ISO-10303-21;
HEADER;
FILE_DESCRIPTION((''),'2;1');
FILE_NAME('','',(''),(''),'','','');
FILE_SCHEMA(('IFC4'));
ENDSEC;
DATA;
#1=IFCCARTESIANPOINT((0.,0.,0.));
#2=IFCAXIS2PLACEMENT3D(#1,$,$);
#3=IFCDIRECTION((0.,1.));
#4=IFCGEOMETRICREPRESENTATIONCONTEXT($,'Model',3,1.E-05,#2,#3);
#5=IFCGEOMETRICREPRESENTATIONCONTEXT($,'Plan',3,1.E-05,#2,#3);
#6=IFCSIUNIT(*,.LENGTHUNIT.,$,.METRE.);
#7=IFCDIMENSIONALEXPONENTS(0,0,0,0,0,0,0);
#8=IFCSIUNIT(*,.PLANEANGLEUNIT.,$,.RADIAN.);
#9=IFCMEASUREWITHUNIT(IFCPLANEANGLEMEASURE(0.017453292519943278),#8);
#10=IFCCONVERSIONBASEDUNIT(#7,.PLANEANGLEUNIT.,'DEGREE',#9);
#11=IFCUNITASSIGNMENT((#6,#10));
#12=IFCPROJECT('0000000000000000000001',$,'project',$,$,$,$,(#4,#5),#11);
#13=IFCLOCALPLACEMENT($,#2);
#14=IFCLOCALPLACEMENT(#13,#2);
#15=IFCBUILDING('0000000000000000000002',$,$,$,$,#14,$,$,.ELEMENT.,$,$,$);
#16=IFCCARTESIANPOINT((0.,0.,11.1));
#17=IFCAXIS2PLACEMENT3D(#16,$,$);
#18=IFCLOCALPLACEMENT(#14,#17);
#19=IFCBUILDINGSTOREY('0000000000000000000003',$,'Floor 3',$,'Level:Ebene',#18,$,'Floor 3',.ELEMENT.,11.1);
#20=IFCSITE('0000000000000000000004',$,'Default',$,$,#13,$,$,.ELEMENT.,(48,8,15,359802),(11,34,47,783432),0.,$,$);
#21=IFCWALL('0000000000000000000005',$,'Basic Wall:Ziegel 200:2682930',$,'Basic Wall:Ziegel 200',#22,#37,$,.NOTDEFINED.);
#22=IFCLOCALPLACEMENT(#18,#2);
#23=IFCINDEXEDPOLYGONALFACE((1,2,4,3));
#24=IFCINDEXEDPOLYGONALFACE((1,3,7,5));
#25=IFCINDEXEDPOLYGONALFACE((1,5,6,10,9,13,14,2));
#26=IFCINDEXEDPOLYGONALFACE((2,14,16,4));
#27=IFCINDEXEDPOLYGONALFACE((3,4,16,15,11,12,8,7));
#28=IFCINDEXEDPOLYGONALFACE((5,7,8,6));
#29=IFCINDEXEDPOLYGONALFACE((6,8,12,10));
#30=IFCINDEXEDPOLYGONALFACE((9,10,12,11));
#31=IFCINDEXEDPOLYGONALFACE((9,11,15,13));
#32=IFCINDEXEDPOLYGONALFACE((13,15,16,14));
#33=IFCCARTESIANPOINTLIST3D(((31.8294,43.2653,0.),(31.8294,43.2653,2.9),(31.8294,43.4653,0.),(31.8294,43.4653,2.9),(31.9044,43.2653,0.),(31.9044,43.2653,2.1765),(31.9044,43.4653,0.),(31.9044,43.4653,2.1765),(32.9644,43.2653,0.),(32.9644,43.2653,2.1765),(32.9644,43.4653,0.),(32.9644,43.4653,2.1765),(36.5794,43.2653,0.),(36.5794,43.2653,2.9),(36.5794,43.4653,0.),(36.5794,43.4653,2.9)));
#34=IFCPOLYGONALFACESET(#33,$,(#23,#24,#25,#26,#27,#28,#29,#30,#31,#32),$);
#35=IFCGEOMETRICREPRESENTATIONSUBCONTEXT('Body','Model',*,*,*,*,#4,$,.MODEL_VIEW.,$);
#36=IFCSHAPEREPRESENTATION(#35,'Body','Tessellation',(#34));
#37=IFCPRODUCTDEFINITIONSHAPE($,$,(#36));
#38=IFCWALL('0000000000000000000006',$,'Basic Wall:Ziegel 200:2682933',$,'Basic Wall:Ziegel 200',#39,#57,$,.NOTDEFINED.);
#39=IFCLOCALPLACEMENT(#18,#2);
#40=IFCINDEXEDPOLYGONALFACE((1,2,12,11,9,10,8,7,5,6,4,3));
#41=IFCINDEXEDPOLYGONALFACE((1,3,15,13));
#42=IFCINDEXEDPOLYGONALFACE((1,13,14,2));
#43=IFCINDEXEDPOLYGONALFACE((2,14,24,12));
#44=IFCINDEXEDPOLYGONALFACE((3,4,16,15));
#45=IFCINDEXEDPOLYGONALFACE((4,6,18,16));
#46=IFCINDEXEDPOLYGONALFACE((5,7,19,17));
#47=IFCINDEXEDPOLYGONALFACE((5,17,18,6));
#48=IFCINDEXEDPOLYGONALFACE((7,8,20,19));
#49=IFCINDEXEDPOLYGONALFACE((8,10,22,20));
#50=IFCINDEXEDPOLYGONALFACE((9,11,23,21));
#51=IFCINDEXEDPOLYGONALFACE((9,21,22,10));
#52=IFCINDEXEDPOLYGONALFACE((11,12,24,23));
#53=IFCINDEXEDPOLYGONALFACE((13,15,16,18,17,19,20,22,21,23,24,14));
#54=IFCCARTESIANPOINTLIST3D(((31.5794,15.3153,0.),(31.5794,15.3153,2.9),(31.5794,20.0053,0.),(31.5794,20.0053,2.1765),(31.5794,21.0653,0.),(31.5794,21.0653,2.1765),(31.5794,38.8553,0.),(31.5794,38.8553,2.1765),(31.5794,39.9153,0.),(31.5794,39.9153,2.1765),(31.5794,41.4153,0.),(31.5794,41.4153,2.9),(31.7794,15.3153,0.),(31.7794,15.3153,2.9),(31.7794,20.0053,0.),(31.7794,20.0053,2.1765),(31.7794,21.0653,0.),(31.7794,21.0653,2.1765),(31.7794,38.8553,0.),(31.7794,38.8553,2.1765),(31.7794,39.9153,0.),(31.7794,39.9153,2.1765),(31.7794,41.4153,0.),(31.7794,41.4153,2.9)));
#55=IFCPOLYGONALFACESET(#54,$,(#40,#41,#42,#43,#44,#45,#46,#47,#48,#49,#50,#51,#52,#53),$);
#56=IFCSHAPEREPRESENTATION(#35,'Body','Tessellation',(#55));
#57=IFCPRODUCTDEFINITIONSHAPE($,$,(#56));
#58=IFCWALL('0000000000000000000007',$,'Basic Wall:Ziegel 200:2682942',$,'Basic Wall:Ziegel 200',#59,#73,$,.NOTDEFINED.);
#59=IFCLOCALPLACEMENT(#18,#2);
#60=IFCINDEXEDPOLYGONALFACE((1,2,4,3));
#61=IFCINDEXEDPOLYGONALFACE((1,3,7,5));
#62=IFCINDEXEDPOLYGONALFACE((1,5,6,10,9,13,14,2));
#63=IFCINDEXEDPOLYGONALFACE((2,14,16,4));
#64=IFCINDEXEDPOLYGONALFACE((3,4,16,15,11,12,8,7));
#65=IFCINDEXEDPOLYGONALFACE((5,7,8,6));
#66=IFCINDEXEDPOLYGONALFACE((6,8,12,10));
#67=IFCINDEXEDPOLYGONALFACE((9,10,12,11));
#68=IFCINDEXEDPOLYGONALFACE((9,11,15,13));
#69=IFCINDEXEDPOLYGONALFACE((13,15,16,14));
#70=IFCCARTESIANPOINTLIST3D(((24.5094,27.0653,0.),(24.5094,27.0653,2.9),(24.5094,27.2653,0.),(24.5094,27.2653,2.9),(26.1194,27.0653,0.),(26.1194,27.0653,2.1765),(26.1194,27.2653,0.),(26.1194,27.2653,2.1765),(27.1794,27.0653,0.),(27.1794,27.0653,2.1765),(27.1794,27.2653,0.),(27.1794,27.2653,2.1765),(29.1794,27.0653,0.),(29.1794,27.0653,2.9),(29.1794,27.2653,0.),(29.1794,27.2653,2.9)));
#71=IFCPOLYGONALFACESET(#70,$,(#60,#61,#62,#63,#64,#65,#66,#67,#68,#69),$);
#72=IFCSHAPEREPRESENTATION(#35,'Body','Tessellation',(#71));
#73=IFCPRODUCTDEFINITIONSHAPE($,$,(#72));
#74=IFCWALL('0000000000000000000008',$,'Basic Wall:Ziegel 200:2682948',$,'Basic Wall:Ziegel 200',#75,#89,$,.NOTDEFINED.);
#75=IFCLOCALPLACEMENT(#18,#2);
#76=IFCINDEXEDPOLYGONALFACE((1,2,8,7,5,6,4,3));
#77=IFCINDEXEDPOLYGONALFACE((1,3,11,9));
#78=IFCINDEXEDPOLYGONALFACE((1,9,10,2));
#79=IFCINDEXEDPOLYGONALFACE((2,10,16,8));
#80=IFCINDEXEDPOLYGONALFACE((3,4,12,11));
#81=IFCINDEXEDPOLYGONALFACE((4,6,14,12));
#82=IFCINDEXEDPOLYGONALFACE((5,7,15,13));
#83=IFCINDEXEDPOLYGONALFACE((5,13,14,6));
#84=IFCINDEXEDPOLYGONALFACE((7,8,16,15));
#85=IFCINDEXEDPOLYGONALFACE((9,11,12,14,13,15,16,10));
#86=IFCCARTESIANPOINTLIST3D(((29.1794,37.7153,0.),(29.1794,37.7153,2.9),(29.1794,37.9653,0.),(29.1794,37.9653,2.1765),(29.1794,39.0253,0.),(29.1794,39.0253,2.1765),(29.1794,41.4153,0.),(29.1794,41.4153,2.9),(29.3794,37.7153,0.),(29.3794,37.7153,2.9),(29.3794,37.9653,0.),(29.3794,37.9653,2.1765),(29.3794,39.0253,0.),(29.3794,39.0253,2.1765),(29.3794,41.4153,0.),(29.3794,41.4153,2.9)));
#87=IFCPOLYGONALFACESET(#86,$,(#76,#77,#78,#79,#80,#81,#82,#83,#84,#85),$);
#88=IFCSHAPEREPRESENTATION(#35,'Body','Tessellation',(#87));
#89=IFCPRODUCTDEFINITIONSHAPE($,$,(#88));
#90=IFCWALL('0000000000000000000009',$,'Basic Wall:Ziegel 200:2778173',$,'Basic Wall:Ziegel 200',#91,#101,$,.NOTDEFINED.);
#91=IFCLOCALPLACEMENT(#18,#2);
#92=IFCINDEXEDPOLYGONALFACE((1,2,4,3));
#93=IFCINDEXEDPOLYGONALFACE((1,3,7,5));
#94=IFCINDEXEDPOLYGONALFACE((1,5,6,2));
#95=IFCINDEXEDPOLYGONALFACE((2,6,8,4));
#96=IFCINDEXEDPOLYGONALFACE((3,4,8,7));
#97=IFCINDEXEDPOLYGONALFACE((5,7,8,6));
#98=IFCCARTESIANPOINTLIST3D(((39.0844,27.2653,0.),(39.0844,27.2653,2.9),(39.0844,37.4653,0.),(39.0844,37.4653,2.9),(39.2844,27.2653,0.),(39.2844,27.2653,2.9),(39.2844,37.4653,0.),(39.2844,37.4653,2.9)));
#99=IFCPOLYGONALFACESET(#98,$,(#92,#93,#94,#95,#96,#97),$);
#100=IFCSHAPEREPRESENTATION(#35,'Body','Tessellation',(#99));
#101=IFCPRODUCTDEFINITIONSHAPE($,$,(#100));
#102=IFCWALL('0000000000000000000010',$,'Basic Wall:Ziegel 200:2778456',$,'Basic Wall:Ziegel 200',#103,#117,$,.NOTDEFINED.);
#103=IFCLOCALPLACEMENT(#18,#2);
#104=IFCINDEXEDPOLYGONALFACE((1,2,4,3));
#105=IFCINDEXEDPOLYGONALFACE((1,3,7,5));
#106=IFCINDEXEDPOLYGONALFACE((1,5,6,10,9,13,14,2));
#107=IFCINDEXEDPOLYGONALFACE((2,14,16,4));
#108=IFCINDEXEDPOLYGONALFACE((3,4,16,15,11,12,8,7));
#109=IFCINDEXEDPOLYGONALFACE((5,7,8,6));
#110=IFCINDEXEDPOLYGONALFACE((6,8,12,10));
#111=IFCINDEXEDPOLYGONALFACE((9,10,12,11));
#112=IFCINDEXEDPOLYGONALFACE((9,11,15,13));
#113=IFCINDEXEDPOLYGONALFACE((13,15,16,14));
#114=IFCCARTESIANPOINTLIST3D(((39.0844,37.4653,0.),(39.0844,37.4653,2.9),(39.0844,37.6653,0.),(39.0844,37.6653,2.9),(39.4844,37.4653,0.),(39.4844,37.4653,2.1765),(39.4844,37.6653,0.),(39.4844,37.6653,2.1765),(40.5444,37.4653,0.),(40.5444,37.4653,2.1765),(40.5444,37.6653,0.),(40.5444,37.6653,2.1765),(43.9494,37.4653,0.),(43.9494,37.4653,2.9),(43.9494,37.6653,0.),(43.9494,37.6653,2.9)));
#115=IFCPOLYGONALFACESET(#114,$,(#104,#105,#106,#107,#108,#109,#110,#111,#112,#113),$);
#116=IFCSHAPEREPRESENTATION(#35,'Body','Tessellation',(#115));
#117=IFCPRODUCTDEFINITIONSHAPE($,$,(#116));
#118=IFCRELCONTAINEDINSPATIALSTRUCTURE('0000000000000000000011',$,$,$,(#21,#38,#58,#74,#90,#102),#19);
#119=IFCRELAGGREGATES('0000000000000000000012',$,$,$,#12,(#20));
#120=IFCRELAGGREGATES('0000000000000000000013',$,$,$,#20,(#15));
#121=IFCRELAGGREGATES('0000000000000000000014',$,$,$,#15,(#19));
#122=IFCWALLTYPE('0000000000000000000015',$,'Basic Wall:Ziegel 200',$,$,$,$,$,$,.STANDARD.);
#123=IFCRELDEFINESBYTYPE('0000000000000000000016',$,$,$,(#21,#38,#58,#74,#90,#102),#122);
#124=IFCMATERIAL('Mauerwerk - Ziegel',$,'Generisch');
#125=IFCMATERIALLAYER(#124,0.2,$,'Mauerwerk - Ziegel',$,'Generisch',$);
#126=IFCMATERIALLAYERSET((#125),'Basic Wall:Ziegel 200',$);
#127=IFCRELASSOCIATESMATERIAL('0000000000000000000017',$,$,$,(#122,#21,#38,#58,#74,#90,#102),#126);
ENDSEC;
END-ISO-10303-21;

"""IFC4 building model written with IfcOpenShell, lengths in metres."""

from ifc_helpers import new_model, entity, si_unit, converted_unit, direction, frame, frame_2d, origin, place, context, subcontext, project, spatial, rectangle, extrude, material, layer, layer_set, layer_usage, type_object, element, save


model = new_model("IFC4")

# Units and contexts
model_context = context("Model", 3, precision=1e-05, world=origin(), true_north=direction((0.0, 1.0)))
plan_context = context("Plan", 3, precision=1e-05, world=origin(), true_north=direction((0.0, 1.0)))
body_context = subcontext(model_context, "Body", "Model", "MODEL_VIEW")
ifc_project = project(units=[si_unit("LENGTHUNIT", "METRE"), converted_unit("PLANEANGLEUNIT", "DEGREE", entity("IfcPlaneAngleMeasure", 0.017453292519943278), si_unit("PLANEANGLEUNIT", "RADIAN"), dimensions=[0, 0, 0, 0, 0, 0, 0])], contexts=[model_context, plan_context])

# Site, building, storey
site_placement = place(None, origin())
site = spatial("IfcSite", under=ifc_project, at=site_placement, Name="Default", CompositionType="ELEMENT", RefLatitude=(48, 8, 15, 359802), RefLongitude=(11, 34, 47, 783432), RefElevation=0.0)
building_placement = place(site_placement, origin())
building = spatial("IfcBuilding", under=site, at=building_placement, CompositionType="ELEMENT")
storey_placement = place(building_placement, frame((0.0, 0.0, 11.1)))
storey = spatial("IfcBuildingStorey", under=building, at=storey_placement, Name="Floor 3", ObjectType="Level:Ebene", LongName="Floor 3", CompositionType="ELEMENT", Elevation=11.1)

# Shared definitions
ifc_material_1 = material(Name="Mauerwerk - Ziegel", Category="Generisch")
ifc_layer_1 = layer(ifc_material_1, 0.2, Name="Mauerwerk - Ziegel", Category="Generisch")
ifc_layer_set_1 = layer_set([ifc_layer_1], Name="Basic Wall:Ziegel 200")
ifc_layer_usage_1 = layer_usage(ifc_layer_set_1, "AXIS2", "NEGATIVE", 0.1)
wall_type_1 = type_object("IfcWallType", Name="Basic Wall:Ziegel 200", PredefinedType="STANDARD", material=ifc_layer_set_1)

# Wall, opening
wall_1_placement = place(storey_placement, frame((31.8294, 43.3653, 0.0)))
wall_1 = element("IfcWall", 1, at=wall_1_placement, inside=storey, type_object=wall_type_1, material=ifc_layer_usage_1, Name="Basic Wall:Ziegel 200:2682930", ObjectType="Basic Wall:Ziegel 200", PredefinedType="NOTDEFINED", context=body_context, shape_type="SweptSolid", body=[
    extrude(rectangle(XDim=4.75, YDim=0.2, at=frame_2d((2.375, 0.0), x_axis=(-1.0, 0.0))), origin(), (0.0, 0.0, 1.0), 2.9),
])
opening_1_placement = place(wall_1_placement, frame((1.135, 0.1, 0.0)))
element("IfcOpeningElement", 2, at=opening_1_placement, cuts=wall_1, PredefinedType="OPENING", context=body_context, shape_type="SweptSolid", body=[
    extrude(rectangle(XDim=2.1765, YDim=1.06, at=frame_2d((1.0882, 0.53), x_axis=(1.0, 0.0))), frame((0.0, 0.0, 0.0), z_axis=(0.0, -1.0, 0.0), x_axis=(0.0, 0.0, 1.0)), (0.0, 0.0, 1.0), 0.2),
])

# Wall, openings
wall_2_placement = place(storey_placement, frame((31.6794, 41.4153, 0.0), z_axis=(0.0, 0.0, 1.0), x_axis=(0.0, -1.0, 0.0)))
wall_2 = element("IfcWall", 3, at=wall_2_placement, inside=storey, type_object=wall_type_1, material=ifc_layer_usage_1, Name="Basic Wall:Ziegel 200:2682933", ObjectType="Basic Wall:Ziegel 200", PredefinedType="NOTDEFINED", context=body_context, shape_type="SweptSolid", body=[
    extrude(rectangle(XDim=26.1, YDim=0.2, at=frame_2d((13.05, 0.0), x_axis=(1.0, 0.0))), origin(), (0.0, 0.0, 1.0), 2.9),
])
opening_2_placement = place(wall_2_placement, frame((21.41, 0.1, 0.0)))
element("IfcOpeningElement", 4, at=opening_2_placement, cuts=wall_2, PredefinedType="OPENING", context=body_context, shape_type="SweptSolid", body=[
    extrude(rectangle(XDim=2.1765, YDim=1.06, at=frame_2d((1.0882, 0.53), x_axis=(1.0, 0.0))), frame((0.0, 0.0, 0.0), z_axis=(0.0, -1.0, 0.0), x_axis=(0.0, 0.0, 1.0)), (0.0, 0.0, 1.0), 0.2),
])
opening_3_placement = place(wall_2_placement, frame((2.56, 0.1, 0.0)))
element("IfcOpeningElement", 5, at=opening_3_placement, cuts=wall_2, PredefinedType="OPENING", context=body_context, shape_type="SweptSolid", body=[
    extrude(rectangle(XDim=2.1765, YDim=1.06, at=frame_2d((1.0882, 0.53), x_axis=(1.0, 0.0))), frame((0.0, 0.0, 0.0), z_axis=(0.0, -1.0, 0.0), x_axis=(0.0, 0.0, 1.0)), (0.0, 0.0, 1.0), 0.2),
])

# Walls, openings
wall_3_placement = place(storey_placement, frame((29.1794, 27.1653, 0.0), z_axis=(0.0, 0.0, 1.0), x_axis=(-1.0, 0.0, 0.0)))
wall_3 = element("IfcWall", 6, at=wall_3_placement, inside=storey, type_object=wall_type_1, material=ifc_layer_usage_1, Name="Basic Wall:Ziegel 200:2682942", ObjectType="Basic Wall:Ziegel 200", PredefinedType="NOTDEFINED", context=body_context, shape_type="SweptSolid", body=[
    extrude(rectangle(XDim=4.67, YDim=0.2, at=frame_2d((2.335, 0.0), x_axis=(-1.0, 0.0))), origin(), (0.0, 0.0, 1.0), 2.9),
])
opening_4_placement = place(wall_3_placement, frame((2.0, -0.1, 0.0)))
element("IfcOpeningElement", 7, at=opening_4_placement, cuts=wall_3, PredefinedType="OPENING", context=body_context, shape_type="SweptSolid", body=[
    extrude(rectangle(XDim=2.1765, YDim=1.06, at=frame_2d((1.0882, 0.53), x_axis=(1.0, 0.0))), frame((0.0, 0.0, 0.0), z_axis=(0.0, 1.0, 0.0), x_axis=(0.0, 0.0, 1.0)), (0.0, 0.0, 1.0), 0.2),
])
wall_4_placement = place(storey_placement, frame((29.2794, 41.4153, 0.0), z_axis=(0.0, 0.0, 1.0), x_axis=(0.0, -1.0, 0.0)))
wall_4 = element("IfcWall", 8, at=wall_4_placement, inside=storey, type_object=wall_type_1, material=ifc_layer_usage_1, Name="Basic Wall:Ziegel 200:2682948", ObjectType="Basic Wall:Ziegel 200", PredefinedType="NOTDEFINED", context=body_context, shape_type="SweptSolid", body=[
    extrude(rectangle(XDim=3.7, YDim=0.2, at=frame_2d((1.85, 0.0), x_axis=(1.0, 0.0))), origin(), (0.0, 0.0, 1.0), 2.9),
])
opening_5_placement = place(wall_4_placement, frame((2.39, -0.1, 0.0)))
element("IfcOpeningElement", 9, at=opening_5_placement, cuts=wall_4, PredefinedType="OPENING", context=body_context, shape_type="SweptSolid", body=[
    extrude(rectangle(XDim=2.1765, YDim=1.06, at=frame_2d((1.0882, 0.53), x_axis=(1.0, 0.0))), frame((0.0, 0.0, 0.0), z_axis=(0.0, 1.0, 0.0), x_axis=(0.0, 0.0, 1.0)), (0.0, 0.0, 1.0), 0.2),
])

# Wall
wall_5_placement = place(storey_placement, frame((39.1844, 37.4653, 0.0), z_axis=(0.0, 0.0, 1.0), x_axis=(0.0, -1.0, 0.0)))
element("IfcWall", 10, at=wall_5_placement, inside=storey, type_object=wall_type_1, material=ifc_layer_usage_1, Name="Basic Wall:Ziegel 200:2778173", ObjectType="Basic Wall:Ziegel 200", PredefinedType="NOTDEFINED", context=body_context, shape_type="SweptSolid", body=[
    extrude(rectangle(XDim=10.2, YDim=0.2, at=frame_2d((5.1, 0.0), x_axis=(-1.0, 0.0))), origin(), (0.0, 0.0, 1.0), 2.9),
])

# Wall, opening
wall_6_placement = place(storey_placement, frame((39.0844, 37.5653, 0.0)))
wall_6 = element("IfcWall", 11, at=wall_6_placement, inside=storey, type_object=wall_type_1, material=ifc_layer_usage_1, Name="Basic Wall:Ziegel 200:2778456", ObjectType="Basic Wall:Ziegel 200", PredefinedType="NOTDEFINED", context=body_context, shape_type="SweptSolid", body=[
    extrude(rectangle(XDim=4.865, YDim=0.2, at=frame_2d((2.4325, 0.0), x_axis=(1.0, 0.0))), origin(), (0.0, 0.0, 1.0), 2.9),
])
opening_6_placement = place(wall_6_placement, frame((1.46, 0.1, 0.0)))
element("IfcOpeningElement", 12, at=opening_6_placement, cuts=wall_6, PredefinedType="OPENING", context=body_context, shape_type="SweptSolid", body=[
    extrude(rectangle(XDim=2.1765, YDim=1.06, at=frame_2d((1.0882, 0.53), x_axis=(1.0, 0.0))), frame((0.0, 0.0, 0.0), z_axis=(0.0, -1.0, 0.0), x_axis=(0.0, 0.0, 1.0)), (0.0, 0.0, 1.0), 0.2),
])

save(model, "model.ifc")
